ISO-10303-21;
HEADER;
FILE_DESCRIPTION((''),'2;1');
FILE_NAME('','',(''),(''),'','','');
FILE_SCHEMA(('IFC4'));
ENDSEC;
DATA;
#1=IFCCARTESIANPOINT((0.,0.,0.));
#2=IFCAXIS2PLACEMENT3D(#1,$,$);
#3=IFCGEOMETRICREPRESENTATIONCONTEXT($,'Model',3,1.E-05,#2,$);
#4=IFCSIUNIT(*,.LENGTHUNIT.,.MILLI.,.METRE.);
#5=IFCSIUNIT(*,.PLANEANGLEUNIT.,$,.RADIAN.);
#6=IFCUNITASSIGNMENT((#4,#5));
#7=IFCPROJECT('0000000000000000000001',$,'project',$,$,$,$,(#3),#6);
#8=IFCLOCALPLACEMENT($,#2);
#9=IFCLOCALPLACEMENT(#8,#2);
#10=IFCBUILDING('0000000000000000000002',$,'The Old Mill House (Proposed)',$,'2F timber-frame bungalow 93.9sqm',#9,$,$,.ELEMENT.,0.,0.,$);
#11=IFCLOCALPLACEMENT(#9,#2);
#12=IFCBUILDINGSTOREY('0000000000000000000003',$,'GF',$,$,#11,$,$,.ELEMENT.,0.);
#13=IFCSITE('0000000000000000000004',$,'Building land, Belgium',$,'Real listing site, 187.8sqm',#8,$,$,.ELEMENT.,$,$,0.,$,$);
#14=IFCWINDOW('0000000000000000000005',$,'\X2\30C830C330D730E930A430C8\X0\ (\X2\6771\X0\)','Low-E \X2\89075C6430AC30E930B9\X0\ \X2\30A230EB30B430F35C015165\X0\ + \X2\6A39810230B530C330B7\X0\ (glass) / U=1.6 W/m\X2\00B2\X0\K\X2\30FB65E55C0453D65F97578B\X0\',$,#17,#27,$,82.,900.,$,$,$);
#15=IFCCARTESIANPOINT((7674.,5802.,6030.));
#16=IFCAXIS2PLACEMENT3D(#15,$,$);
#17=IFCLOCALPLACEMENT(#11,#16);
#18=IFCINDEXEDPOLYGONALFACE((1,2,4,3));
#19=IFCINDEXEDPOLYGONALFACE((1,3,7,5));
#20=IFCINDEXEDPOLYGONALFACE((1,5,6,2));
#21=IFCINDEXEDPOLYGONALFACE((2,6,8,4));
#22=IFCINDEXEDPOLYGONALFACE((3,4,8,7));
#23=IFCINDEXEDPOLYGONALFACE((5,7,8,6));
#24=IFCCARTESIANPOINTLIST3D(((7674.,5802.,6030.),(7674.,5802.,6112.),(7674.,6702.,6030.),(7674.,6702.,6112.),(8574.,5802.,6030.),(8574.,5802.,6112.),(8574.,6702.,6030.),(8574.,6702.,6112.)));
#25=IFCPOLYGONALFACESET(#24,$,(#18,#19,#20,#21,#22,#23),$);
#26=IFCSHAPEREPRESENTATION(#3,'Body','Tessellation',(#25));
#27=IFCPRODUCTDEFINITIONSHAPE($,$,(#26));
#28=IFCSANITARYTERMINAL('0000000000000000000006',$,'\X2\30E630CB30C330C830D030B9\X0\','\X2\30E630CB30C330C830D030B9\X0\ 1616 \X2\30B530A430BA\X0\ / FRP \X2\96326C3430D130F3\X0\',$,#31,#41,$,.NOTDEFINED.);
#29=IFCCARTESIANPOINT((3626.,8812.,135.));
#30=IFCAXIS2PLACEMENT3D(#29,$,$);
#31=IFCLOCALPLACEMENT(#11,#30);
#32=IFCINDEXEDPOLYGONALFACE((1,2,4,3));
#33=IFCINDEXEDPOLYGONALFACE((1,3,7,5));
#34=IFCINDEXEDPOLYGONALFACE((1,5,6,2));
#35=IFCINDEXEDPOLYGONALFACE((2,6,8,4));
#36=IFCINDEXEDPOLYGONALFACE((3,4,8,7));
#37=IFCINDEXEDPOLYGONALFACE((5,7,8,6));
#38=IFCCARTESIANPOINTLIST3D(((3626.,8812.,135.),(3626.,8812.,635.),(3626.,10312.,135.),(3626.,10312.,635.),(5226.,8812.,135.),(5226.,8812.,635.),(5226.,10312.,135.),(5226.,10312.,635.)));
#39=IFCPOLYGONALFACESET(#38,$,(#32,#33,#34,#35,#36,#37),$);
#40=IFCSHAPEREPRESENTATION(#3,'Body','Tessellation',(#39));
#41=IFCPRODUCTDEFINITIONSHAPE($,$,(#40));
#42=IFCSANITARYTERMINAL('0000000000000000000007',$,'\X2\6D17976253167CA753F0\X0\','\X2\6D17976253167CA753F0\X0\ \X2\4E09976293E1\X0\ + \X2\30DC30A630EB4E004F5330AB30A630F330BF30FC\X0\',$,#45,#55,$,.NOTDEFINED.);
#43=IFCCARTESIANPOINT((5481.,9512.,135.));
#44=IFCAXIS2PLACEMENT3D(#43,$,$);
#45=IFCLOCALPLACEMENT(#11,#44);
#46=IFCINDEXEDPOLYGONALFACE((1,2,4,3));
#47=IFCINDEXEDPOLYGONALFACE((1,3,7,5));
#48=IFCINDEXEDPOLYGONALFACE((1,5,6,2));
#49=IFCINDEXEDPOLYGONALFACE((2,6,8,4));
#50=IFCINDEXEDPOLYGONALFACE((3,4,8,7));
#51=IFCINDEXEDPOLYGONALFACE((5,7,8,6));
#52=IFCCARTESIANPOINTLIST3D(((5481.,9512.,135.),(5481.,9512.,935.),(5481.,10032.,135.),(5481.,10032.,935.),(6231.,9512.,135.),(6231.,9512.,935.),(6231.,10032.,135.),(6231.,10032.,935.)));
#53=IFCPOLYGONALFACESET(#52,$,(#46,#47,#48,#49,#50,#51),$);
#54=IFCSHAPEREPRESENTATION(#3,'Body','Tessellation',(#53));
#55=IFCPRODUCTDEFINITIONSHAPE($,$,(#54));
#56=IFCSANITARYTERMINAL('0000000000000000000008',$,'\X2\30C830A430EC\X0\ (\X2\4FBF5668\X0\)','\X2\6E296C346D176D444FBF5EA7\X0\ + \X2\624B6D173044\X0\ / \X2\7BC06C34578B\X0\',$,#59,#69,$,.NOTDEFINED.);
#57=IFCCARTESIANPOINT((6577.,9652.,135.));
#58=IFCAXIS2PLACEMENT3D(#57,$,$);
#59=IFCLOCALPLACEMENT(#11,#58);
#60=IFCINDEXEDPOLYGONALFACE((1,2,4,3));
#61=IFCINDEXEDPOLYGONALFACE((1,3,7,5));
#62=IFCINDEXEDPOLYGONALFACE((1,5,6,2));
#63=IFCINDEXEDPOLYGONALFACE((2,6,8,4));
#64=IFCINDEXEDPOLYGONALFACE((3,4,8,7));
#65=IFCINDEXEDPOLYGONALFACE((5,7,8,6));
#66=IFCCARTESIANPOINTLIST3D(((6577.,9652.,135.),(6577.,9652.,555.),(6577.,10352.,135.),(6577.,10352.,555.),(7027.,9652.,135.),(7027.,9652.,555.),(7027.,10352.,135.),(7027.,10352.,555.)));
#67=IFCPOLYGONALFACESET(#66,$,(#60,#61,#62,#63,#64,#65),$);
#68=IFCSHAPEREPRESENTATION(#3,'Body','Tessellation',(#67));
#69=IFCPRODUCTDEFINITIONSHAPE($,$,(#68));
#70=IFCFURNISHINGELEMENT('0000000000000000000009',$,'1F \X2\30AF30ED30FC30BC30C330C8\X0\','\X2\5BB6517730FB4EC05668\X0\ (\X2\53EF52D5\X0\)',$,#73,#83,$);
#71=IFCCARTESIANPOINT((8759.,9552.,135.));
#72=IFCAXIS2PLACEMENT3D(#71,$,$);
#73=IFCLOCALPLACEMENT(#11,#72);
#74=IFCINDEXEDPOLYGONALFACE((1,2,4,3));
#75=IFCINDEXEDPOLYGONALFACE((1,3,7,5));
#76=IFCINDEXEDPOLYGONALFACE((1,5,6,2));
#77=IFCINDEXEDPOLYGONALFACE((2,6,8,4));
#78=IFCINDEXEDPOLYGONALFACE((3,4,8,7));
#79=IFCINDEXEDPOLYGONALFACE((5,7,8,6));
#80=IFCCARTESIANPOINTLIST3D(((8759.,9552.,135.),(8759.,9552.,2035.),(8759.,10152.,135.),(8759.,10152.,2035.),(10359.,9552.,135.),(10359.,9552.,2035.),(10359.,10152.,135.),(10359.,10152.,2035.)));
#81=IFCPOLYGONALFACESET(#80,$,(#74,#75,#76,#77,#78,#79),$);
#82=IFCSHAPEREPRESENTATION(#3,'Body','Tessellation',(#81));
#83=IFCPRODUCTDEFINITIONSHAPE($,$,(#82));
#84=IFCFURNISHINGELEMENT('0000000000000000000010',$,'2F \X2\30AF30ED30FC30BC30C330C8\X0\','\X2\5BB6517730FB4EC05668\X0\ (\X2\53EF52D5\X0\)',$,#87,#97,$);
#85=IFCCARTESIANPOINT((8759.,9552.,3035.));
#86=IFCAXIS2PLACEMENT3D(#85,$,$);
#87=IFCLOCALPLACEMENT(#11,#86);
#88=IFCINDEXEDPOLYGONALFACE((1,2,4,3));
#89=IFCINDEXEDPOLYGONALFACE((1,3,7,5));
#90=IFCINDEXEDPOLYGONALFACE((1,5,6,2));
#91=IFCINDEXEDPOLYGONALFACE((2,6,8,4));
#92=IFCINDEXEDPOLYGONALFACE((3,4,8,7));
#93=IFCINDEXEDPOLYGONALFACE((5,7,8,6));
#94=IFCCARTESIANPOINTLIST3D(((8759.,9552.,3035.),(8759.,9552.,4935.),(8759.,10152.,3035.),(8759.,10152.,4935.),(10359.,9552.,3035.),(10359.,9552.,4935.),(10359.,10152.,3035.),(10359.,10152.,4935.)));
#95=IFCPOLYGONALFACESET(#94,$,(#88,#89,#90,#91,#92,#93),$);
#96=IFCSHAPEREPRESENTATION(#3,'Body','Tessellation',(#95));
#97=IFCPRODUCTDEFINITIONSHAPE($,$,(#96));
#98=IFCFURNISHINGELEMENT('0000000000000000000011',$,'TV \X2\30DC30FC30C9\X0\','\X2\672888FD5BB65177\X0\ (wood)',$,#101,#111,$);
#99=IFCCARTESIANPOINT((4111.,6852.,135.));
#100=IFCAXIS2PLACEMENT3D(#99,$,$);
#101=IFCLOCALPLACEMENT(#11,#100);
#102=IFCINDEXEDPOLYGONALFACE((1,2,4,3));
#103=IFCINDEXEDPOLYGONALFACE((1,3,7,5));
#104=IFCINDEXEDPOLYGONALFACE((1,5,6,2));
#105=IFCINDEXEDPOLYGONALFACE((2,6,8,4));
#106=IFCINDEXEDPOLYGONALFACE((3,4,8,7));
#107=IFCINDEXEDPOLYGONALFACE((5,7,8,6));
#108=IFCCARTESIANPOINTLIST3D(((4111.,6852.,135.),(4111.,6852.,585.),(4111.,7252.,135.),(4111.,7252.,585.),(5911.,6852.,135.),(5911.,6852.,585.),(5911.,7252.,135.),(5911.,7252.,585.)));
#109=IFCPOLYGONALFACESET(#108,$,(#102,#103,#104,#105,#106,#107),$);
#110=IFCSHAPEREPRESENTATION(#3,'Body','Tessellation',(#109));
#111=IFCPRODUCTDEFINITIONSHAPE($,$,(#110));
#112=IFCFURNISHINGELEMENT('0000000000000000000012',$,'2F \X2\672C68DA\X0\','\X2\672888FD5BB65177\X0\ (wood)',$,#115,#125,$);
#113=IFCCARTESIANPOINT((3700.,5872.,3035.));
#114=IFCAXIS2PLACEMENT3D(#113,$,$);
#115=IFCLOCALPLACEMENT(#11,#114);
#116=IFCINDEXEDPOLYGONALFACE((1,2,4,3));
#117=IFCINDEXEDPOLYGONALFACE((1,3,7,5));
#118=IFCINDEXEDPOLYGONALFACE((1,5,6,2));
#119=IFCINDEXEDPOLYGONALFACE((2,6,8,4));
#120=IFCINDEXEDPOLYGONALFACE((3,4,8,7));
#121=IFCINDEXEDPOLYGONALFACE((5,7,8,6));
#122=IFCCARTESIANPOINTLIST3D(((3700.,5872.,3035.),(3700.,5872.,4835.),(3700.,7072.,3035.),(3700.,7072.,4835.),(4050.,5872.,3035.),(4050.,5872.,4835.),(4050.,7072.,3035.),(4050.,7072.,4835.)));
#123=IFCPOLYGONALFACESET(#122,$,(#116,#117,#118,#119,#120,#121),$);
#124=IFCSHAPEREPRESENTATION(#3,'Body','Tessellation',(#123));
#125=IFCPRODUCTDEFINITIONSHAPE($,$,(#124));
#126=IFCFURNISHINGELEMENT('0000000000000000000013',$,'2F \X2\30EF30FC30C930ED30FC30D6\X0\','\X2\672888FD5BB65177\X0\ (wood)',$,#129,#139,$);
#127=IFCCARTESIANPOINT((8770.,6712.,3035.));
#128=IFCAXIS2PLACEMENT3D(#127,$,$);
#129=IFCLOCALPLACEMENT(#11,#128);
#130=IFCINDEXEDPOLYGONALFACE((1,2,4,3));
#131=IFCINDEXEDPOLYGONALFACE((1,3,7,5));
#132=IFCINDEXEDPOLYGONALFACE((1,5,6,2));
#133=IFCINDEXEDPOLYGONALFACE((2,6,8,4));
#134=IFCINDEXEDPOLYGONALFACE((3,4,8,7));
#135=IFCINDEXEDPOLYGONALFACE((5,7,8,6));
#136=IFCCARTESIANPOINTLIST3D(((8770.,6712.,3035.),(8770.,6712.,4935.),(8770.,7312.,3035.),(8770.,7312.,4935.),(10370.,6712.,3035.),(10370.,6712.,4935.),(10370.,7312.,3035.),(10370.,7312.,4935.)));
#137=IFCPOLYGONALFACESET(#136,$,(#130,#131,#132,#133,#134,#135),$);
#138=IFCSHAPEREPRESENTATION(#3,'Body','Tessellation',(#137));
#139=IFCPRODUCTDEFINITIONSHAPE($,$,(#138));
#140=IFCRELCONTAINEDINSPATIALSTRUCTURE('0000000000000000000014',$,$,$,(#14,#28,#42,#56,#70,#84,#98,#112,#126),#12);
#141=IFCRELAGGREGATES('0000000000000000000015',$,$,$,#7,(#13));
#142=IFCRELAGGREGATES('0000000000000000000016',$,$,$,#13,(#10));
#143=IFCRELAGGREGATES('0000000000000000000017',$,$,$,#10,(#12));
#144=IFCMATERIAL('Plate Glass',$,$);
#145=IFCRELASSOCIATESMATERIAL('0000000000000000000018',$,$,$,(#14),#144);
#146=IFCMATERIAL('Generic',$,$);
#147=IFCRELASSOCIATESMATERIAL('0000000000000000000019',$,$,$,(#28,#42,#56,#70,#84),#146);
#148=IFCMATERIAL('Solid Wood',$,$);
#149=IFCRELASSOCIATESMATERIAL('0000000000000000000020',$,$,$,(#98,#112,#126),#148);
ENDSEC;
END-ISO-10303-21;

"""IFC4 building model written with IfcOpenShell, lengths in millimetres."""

from ifc_helpers import new_model, si_unit, frame, frame_2d, origin, place, context, project, spatial, rectangle, extrude, material, element, save


model = new_model("IFC4")

# Units and contexts
model_context = context("Model", 3, precision=1e-05, world=origin())
ifc_project = project(units=[si_unit("LENGTHUNIT", "METRE", prefix="MILLI"), si_unit("PLANEANGLEUNIT", "RADIAN")], contexts=[model_context])

# Site, building, storey
site_placement = place(None, origin())
site = spatial("IfcSite", under=ifc_project, at=site_placement, Name="Building land, Belgium", ObjectType="Real listing site, 187.8sqm", CompositionType="ELEMENT", RefElevation=0.0)
building_placement = place(site_placement, origin())
building = spatial("IfcBuilding", under=site, at=building_placement, Name="The Old Mill House (Proposed)", ObjectType="2F timber-frame bungalow 93.9sqm", CompositionType="ELEMENT", ElevationOfRefHeight=0.0, ElevationOfTerrain=0.0)
storey_placement = place(building_placement, origin())
storey = spatial("IfcBuildingStorey", under=building, at=storey_placement, Name="GF", CompositionType="ELEMENT", Elevation=0.0)

# Shared definitions
ifc_material_1 = material(Name="Solid Wood")
ifc_material_2 = material(Name="Plate Glass")

# Window
window_1_placement = place(storey_placement, frame((7674.0, 5802.0, 6030.0)))
element("IfcWindow", 1, at=window_1_placement, inside=storey, material=ifc_material_2, Name="トップライト (東)", Description="Low-E 複層ガラス アルゴン封入 + 樹脂サッシ (glass) / U=1.6 W/m²K・日射取得型", OverallHeight=82.0, OverallWidth=900.0, context=model_context, shape_type="SweptSolid", body=[
    extrude(rectangle(XDim=900.0, YDim=900.0, at=frame_2d((450.0, 450.0))), frame((7674.0, 5802.0, 6030.0)), (0.0, 0.0, 1.0), 82.0),
])

# Sanitary terminals
ifc_material_3 = material(Name="Generic")
sanitary_terminal_1_placement = place(storey_placement, frame((3626.0, 8812.0, 135.0)))
element("IfcSanitaryTerminal", 2, at=sanitary_terminal_1_placement, inside=storey, material=ifc_material_3, Name="ユニットバス", Description="ユニットバス 1616 サイズ / FRP 防水パン", PredefinedType="NOTDEFINED", context=model_context, shape_type="SweptSolid", body=[
    extrude(rectangle(XDim=1600.0, YDim=1500.0, at=frame_2d((800.0, 750.0))), frame((3626.0, 8812.0, 135.0)), (0.0, 0.0, 1.0), 500.0),
])
sanitary_terminal_2_placement = place(storey_placement, frame((5481.0, 9512.0, 135.0)))
element("IfcSanitaryTerminal", 3, at=sanitary_terminal_2_placement, inside=storey, material=ifc_material_3, Name="洗面化粧台", Description="洗面化粧台 三面鏡 + ボウル一体カウンター", PredefinedType="NOTDEFINED", context=model_context, shape_type="SweptSolid", body=[
    extrude(rectangle(XDim=750.0, YDim=520.0, at=frame_2d((375.0, 260.0))), frame((5481.0, 9512.0, 135.0)), (0.0, 0.0, 1.0), 800.0),
])
sanitary_terminal_3_placement = place(storey_placement, frame((6577.0, 9652.0, 135.0)))
element("IfcSanitaryTerminal", 4, at=sanitary_terminal_3_placement, inside=storey, material=ifc_material_3, Name="トイレ (便器)", Description="温水洗浄便座 + 手洗い / 節水型", PredefinedType="NOTDEFINED", context=model_context, shape_type="SweptSolid", body=[
    extrude(rectangle(XDim=450.0, YDim=700.0, at=frame_2d((225.0, 350.0))), frame((6577.0, 9652.0, 135.0)), (0.0, 0.0, 1.0), 420.0),
])

# Furnishing elements
furnishing_1_placement = place(storey_placement, frame((8759.0, 9552.0, 135.0)))
element("IfcFurnishingElement", 5, at=furnishing_1_placement, inside=storey, material=ifc_material_3, Name="1F クローゼット", Description="家具・什器 (可動)", context=model_context, shape_type="SweptSolid", body=[
    extrude(rectangle(XDim=1600.0, YDim=600.0, at=frame_2d((800.0, 300.0))), frame((8759.0, 9552.0, 135.0)), (0.0, 0.0, 1.0), 1900.0),
])
furnishing_2_placement = place(storey_placement, frame((8759.0, 9552.0, 3035.0)))
element("IfcFurnishingElement", 6, at=furnishing_2_placement, inside=storey, material=ifc_material_3, Name="2F クローゼット", Description="家具・什器 (可動)", context=model_context, shape_type="SweptSolid", body=[
    extrude(rectangle(XDim=1600.0, YDim=600.0, at=frame_2d((800.0, 300.0))), frame((8759.0, 9552.0, 3035.0)), (0.0, 0.0, 1.0), 1900.0),
])
furnishing_3_placement = place(storey_placement, frame((4111.0, 6852.0, 135.0)))
element("IfcFurnishingElement", 7, at=furnishing_3_placement, inside=storey, material=ifc_material_1, Name="TV ボード", Description="木製家具 (wood)", context=model_context, shape_type="SweptSolid", body=[
    extrude(rectangle(XDim=1800.0, YDim=400.0, at=frame_2d((900.0, 200.0))), frame((4111.0, 6852.0, 135.0)), (0.0, 0.0, 1.0), 450.0),
])
furnishing_4_placement = place(storey_placement, frame((3700.0, 5872.0, 3035.0)))
element("IfcFurnishingElement", 8, at=furnishing_4_placement, inside=storey, material=ifc_material_1, Name="2F 本棚", Description="木製家具 (wood)", context=model_context, shape_type="SweptSolid", body=[
    extrude(rectangle(XDim=350.0, YDim=1200.0, at=frame_2d((175.0, 600.0))), frame((3700.0, 5872.0, 3035.0)), (0.0, 0.0, 1.0), 1800.0),
])
furnishing_5_placement = place(storey_placement, frame((8770.0, 6712.0, 3035.0)))
element("IfcFurnishingElement", 9, at=furnishing_5_placement, inside=storey, material=ifc_material_1, Name="2F ワードローブ", Description="木製家具 (wood)", context=model_context, shape_type="SweptSolid", body=[
    extrude(rectangle(XDim=1600.0, YDim=600.0, at=frame_2d((800.0, 300.0))), frame((8770.0, 6712.0, 3035.0)), (0.0, 0.0, 1.0), 1900.0),
])

save(model, "model.ifc")
